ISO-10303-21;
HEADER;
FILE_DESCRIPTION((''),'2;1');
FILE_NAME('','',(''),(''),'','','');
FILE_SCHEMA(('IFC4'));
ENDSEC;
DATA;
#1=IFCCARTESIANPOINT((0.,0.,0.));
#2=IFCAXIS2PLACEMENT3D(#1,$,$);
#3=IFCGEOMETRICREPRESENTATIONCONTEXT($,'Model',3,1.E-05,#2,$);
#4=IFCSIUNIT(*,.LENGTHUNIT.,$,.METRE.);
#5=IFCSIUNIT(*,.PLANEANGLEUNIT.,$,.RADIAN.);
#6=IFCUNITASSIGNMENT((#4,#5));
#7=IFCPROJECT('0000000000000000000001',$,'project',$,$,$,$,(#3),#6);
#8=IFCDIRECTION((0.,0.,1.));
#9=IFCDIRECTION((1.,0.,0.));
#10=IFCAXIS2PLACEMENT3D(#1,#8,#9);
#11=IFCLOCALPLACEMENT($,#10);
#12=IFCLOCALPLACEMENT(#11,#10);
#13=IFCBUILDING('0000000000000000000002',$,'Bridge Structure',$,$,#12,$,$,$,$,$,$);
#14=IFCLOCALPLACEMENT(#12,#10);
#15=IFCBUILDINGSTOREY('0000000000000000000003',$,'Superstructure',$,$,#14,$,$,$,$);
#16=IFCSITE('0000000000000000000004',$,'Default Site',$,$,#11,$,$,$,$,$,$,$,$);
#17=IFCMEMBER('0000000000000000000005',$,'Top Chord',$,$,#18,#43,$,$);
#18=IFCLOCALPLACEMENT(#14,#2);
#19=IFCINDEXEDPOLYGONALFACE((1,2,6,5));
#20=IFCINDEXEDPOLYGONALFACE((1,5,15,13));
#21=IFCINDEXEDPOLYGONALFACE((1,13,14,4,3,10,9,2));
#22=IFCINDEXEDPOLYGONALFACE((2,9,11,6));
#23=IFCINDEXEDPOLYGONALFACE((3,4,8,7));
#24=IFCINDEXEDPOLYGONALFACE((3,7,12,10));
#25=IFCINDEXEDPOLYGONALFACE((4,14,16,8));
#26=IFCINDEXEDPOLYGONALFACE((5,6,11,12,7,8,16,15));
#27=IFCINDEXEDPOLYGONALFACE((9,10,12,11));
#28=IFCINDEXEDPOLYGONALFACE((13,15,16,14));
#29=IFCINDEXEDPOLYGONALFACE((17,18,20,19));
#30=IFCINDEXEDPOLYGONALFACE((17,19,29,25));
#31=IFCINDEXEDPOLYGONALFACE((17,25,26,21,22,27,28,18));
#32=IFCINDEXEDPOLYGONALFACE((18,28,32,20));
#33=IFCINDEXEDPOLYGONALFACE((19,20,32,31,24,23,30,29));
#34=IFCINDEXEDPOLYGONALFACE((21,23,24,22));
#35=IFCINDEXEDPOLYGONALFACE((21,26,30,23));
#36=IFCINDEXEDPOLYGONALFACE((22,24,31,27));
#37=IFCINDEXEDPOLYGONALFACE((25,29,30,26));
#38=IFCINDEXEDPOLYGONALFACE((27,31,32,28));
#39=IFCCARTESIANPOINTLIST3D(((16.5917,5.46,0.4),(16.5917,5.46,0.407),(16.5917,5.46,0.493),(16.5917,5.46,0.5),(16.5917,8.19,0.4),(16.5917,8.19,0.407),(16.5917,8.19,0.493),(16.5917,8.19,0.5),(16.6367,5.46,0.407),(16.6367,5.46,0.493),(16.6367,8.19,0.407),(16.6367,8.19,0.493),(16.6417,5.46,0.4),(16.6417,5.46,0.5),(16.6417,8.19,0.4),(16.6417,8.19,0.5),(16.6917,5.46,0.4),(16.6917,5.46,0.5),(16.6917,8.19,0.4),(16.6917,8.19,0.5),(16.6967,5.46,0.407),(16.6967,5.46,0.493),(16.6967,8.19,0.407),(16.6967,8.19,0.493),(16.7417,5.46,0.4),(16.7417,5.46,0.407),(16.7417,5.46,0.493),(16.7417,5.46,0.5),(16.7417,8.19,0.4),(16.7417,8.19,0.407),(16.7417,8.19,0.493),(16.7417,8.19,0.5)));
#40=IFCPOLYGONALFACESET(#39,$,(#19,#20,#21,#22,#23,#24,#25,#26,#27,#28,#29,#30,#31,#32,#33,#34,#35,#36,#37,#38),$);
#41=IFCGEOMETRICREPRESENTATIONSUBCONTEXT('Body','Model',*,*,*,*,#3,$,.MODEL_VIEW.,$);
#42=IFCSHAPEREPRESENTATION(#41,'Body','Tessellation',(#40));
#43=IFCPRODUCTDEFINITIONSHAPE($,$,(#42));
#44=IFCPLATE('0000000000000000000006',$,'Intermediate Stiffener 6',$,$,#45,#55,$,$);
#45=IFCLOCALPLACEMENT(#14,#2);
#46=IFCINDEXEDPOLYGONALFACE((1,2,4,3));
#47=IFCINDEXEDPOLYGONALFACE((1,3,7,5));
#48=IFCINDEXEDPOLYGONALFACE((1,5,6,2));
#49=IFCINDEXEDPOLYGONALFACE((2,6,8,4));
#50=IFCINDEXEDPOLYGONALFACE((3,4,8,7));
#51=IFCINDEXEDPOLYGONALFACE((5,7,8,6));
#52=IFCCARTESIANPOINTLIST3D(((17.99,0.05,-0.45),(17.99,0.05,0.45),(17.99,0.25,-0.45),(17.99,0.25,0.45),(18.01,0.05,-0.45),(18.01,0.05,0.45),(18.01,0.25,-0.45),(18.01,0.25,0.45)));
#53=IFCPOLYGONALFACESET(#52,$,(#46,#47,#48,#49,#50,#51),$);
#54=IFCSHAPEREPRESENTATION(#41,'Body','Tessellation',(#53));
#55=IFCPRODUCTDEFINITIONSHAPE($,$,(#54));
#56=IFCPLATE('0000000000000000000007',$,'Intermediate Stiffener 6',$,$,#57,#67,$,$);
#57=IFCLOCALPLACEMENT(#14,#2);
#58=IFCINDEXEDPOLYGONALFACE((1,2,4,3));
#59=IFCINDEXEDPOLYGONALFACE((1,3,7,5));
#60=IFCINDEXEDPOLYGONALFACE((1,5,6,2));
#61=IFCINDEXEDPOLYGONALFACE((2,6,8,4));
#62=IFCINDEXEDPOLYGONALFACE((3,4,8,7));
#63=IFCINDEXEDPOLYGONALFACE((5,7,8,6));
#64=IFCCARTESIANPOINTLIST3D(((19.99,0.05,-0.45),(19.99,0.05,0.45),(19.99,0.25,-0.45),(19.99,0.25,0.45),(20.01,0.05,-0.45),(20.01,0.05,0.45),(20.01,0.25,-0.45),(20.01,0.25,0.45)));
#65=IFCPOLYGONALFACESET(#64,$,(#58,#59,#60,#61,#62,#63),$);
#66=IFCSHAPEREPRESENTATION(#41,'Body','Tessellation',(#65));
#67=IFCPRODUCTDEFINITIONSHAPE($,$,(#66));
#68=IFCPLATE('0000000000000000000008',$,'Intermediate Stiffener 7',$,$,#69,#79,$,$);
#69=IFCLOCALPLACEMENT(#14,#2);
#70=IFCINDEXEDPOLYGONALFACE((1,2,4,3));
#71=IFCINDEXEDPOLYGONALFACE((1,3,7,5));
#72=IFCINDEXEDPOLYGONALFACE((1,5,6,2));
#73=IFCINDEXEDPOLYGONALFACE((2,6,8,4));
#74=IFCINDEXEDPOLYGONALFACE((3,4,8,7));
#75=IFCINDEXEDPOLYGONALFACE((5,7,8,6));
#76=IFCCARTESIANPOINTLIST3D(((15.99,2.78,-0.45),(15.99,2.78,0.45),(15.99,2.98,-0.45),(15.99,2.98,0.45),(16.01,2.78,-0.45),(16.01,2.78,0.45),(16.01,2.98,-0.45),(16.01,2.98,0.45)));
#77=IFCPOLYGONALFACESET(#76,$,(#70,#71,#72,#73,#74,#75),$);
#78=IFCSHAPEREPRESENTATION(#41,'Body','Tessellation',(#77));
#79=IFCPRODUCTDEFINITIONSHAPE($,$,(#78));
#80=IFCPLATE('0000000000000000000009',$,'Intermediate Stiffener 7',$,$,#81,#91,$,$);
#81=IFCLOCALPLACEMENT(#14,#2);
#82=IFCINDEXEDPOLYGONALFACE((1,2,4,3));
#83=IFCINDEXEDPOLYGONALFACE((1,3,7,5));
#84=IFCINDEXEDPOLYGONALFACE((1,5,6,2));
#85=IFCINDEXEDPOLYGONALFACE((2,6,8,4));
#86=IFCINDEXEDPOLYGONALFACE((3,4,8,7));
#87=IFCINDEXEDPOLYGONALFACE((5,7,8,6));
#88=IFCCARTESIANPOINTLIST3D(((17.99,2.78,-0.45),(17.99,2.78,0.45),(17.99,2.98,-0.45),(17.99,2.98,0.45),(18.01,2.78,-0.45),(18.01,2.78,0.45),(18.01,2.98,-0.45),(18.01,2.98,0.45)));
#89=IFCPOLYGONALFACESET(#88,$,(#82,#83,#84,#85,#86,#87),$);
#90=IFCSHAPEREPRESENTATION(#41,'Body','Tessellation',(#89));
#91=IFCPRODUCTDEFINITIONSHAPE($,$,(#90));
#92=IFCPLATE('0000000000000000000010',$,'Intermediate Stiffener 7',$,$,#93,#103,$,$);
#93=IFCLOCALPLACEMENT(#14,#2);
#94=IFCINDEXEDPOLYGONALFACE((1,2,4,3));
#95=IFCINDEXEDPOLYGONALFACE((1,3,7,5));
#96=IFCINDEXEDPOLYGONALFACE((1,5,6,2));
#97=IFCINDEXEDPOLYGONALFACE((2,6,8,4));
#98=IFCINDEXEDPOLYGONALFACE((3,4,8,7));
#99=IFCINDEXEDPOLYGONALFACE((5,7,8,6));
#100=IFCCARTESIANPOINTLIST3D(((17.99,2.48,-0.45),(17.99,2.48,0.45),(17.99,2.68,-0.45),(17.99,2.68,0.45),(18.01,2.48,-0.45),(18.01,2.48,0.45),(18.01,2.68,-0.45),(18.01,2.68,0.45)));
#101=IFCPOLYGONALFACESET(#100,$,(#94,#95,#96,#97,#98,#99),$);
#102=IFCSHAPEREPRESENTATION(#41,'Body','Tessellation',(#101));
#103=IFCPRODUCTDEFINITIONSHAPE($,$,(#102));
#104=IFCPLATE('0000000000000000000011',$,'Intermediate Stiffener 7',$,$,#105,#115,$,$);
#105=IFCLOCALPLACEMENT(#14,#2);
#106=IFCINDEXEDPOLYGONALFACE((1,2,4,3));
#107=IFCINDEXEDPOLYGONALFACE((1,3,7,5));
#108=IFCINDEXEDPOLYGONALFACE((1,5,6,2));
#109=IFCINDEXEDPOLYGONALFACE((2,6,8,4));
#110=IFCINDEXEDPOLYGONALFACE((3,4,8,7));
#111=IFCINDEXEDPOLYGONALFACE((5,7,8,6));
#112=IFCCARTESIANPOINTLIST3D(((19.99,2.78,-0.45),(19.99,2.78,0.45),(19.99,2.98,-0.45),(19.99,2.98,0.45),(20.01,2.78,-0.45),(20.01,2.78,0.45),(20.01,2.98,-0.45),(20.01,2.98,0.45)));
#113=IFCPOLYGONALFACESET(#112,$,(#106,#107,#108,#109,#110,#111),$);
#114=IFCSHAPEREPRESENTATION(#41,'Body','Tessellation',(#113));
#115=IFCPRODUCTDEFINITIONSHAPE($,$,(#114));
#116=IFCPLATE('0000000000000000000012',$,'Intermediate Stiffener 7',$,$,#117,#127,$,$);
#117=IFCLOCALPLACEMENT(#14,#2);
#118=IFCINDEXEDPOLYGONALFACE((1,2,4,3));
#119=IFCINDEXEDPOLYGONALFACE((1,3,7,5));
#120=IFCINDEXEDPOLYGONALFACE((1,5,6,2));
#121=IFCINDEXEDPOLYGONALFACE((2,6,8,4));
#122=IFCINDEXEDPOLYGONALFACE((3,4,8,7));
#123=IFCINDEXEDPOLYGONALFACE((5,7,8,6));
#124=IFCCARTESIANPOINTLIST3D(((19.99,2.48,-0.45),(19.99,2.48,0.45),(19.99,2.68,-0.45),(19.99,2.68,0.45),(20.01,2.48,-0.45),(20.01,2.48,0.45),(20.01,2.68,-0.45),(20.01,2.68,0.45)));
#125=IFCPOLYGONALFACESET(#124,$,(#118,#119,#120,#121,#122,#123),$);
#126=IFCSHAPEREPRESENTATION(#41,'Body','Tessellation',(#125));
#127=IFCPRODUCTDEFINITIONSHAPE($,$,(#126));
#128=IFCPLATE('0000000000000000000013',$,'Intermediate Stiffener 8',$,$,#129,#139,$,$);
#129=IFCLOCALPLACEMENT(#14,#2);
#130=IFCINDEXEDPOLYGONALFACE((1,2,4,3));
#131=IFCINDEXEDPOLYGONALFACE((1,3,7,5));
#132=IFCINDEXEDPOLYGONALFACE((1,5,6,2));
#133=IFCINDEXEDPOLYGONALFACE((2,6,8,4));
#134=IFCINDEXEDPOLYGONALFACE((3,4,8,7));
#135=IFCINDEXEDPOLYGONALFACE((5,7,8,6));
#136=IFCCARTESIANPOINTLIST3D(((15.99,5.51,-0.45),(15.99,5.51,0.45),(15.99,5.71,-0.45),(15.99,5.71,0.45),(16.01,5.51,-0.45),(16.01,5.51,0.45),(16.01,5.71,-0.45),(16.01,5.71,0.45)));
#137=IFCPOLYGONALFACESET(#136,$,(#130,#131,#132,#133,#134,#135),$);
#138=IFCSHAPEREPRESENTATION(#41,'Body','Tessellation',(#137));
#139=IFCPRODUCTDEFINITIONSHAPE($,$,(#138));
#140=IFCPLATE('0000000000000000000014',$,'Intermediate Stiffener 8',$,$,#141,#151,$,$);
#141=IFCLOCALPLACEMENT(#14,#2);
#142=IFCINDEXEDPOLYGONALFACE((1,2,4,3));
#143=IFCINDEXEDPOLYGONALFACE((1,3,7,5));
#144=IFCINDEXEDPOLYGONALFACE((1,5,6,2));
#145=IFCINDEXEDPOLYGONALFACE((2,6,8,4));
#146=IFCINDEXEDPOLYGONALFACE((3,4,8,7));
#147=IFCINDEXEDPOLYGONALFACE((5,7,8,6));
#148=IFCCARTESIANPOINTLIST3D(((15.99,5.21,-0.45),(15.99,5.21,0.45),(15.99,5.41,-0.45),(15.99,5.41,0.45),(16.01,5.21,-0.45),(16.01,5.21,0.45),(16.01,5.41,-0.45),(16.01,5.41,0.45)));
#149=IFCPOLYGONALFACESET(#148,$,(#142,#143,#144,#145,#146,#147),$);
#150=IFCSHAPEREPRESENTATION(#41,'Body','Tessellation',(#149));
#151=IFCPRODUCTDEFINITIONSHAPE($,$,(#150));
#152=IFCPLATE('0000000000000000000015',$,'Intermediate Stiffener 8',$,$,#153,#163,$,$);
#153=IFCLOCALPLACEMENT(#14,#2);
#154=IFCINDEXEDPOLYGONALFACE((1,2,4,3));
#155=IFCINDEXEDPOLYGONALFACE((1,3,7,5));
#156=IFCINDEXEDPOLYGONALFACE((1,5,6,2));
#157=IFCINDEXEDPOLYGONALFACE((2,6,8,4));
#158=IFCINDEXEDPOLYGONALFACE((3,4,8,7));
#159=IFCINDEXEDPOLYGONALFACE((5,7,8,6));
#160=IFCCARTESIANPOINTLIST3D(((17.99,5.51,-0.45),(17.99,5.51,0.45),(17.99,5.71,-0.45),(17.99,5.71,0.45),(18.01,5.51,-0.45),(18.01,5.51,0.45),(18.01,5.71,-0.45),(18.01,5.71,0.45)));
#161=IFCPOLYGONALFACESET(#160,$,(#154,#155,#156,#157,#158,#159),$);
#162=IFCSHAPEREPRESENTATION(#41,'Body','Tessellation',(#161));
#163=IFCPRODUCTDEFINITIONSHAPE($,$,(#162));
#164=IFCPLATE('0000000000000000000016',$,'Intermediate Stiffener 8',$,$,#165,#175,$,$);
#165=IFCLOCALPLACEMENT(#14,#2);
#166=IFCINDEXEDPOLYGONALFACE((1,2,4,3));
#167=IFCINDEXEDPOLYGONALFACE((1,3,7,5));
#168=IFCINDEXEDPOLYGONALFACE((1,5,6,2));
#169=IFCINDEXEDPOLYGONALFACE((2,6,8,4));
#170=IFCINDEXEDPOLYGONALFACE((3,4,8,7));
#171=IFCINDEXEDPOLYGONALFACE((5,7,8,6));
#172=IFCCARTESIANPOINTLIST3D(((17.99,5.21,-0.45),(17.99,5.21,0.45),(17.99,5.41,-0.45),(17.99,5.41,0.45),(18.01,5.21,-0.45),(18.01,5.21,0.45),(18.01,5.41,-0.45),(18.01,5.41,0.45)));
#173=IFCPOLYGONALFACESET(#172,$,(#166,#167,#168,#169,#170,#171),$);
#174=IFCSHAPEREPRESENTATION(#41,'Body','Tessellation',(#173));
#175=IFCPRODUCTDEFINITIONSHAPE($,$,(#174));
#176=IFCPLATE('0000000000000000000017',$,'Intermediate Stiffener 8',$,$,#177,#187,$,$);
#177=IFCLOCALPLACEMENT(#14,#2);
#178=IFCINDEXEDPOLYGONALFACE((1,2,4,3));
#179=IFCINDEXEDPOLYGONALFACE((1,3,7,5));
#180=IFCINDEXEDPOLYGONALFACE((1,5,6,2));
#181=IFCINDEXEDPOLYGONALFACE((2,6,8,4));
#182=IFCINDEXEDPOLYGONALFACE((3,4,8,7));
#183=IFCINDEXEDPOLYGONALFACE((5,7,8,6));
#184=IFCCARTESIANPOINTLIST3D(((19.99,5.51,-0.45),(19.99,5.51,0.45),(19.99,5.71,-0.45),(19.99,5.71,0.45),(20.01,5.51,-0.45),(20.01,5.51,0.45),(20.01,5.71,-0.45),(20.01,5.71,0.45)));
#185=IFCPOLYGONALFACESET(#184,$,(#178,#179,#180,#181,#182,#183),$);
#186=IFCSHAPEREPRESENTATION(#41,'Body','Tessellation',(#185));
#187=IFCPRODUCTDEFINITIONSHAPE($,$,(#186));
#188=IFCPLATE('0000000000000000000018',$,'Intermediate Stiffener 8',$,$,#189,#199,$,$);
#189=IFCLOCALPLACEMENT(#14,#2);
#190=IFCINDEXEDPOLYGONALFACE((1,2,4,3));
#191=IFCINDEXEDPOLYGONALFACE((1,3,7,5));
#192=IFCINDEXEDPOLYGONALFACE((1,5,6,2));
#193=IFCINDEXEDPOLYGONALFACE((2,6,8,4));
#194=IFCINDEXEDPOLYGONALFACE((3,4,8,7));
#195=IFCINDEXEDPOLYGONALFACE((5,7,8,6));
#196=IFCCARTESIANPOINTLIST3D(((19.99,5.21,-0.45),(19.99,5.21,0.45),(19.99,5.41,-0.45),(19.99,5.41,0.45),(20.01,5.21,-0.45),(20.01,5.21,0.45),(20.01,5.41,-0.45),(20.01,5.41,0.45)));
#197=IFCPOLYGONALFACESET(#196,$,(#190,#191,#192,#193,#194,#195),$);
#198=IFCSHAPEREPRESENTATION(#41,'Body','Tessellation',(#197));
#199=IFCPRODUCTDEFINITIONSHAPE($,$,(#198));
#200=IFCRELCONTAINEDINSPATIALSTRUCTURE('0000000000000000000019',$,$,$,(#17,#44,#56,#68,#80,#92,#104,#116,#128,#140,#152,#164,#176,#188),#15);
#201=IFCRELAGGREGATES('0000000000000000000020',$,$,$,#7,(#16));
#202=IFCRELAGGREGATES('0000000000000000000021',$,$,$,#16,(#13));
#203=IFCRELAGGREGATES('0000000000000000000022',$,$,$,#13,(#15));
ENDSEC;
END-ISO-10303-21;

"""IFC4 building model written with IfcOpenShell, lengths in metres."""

from ifc_helpers import new_model, si_unit, frame, origin, origin_with_axes, origin_2d_with_axis, place, context, subcontext, project, spatial, polyline, rectangle, outline, composite_profile, extrude, element, save


model = new_model("IFC4")

# Units and contexts
model_context = context("Model", 3, precision=1e-05, world=origin())
body_context = subcontext(model_context, "Body", "Model", "MODEL_VIEW")
ifc_project = project(units=[si_unit("LENGTHUNIT", "METRE"), si_unit("PLANEANGLEUNIT", "RADIAN")], contexts=[model_context])

# Site, building, storey
site_placement = place(None, origin_with_axes())
site = spatial("IfcSite", under=ifc_project, at=site_placement, Name="Default Site")
building_placement = place(site_placement, origin_with_axes())
building = spatial("IfcBuilding", under=site, at=building_placement, Name="Bridge Structure")
storey_placement = place(building_placement, origin_with_axes())
storey = spatial("IfcBuildingStorey", under=building, at=storey_placement, Name="Superstructure")

# Member
member_1_placement = place(storey_placement, frame((16.6667, 5.46, 0.45), z_axis=(0.0, 1.0, 0.0), x_axis=(-1.0, 0.0, 0.0)))
element("IfcMember", 1, at=member_1_placement, inside=storey, Name="Top Chord", context=body_context, shape_type="SweptSolid", body=[
    extrude(composite_profile([outline(polyline([(-0.025, -0.05), (-0.025, 0.05), (-0.075, 0.05), (-0.075, 0.043), (-0.03, 0.043), (-0.03, -0.043), (-0.075, -0.043), (-0.075, -0.05), (-0.025, -0.05)])), outline(polyline([(0.025, -0.05), (0.075, -0.05), (0.075, -0.043), (0.03, -0.043), (0.03, 0.043), (0.075, 0.043), (0.075, 0.05), (0.025, 0.05), (0.025, -0.05)]))]), origin_with_axes(), (0.0, 0.0, 1.0), 2.73),
])

# Plates
for number, where, z_axis, x_axis, name in (
    (2, (18.0, 0.15, -0.45), (0.0, 0.0, 1.0), (1.0, 0.0, 0.0), "Intermediate Stiffener 6"),
    (3, (20.0, 0.15, -0.45), (0.0, 0.0, 1.0), (1.0, 0.0, 0.0), "Intermediate Stiffener 6"),
    (4, (16.0, 2.88, -0.45), (0.0, 0.0, 1.0), (1.0, 0.0, 0.0), "Intermediate Stiffener 7"),
    (5, (18.0, 2.88, -0.45), (0.0, 0.0, 1.0), (1.0, 0.0, 0.0), "Intermediate Stiffener 7"),
    (6, (18.0, 2.58, -0.45), (0.0, 0.0, 1.0), (1.0, 0.0, 0.0), "Intermediate Stiffener 7"),
    (7, (20.0, 2.88, -0.45), (0.0, 0.0, 1.0), (1.0, 0.0, 0.0), "Intermediate Stiffener 7"),
    (8, (20.0, 2.58, -0.45), (0.0, 0.0, 1.0), (1.0, 0.0, 0.0), "Intermediate Stiffener 7"),
    (9, (16.0, 5.61, -0.45), (0.0, 0.0, 1.0), (1.0, 0.0, 0.0), "Intermediate Stiffener 8"),
    (10, (16.0, 5.31, -0.45), (0.0, 0.0, 1.0), (1.0, 0.0, 0.0), "Intermediate Stiffener 8"),
    (11, (18.0, 5.61, -0.45), (0.0, 0.0, 1.0), (1.0, 0.0, 0.0), "Intermediate Stiffener 8"),
    (12, (18.0, 5.31, -0.45), (0.0, 0.0, 1.0), (1.0, 0.0, 0.0), "Intermediate Stiffener 8"),
    (13, (20.0, 5.61, -0.45), (0.0, 0.0, 1.0), (1.0, 0.0, 0.0), "Intermediate Stiffener 8"),
    (14, (20.0, 5.31, -0.45), (0.0, 0.0, 1.0), (1.0, 0.0, 0.0), "Intermediate Stiffener 8"),
):
    element("IfcPlate", number, at=place(storey_placement, frame(where, z_axis=z_axis, x_axis=x_axis)), inside=storey, Name=name, context=body_context, shape_type="SweptSolid", body=[
        extrude(rectangle(XDim=0.02, YDim=0.2, at=origin_2d_with_axis()), origin_with_axes(), (0.0, 0.0, 1.0), 0.9),
    ])

save(model, "model.ifc")
